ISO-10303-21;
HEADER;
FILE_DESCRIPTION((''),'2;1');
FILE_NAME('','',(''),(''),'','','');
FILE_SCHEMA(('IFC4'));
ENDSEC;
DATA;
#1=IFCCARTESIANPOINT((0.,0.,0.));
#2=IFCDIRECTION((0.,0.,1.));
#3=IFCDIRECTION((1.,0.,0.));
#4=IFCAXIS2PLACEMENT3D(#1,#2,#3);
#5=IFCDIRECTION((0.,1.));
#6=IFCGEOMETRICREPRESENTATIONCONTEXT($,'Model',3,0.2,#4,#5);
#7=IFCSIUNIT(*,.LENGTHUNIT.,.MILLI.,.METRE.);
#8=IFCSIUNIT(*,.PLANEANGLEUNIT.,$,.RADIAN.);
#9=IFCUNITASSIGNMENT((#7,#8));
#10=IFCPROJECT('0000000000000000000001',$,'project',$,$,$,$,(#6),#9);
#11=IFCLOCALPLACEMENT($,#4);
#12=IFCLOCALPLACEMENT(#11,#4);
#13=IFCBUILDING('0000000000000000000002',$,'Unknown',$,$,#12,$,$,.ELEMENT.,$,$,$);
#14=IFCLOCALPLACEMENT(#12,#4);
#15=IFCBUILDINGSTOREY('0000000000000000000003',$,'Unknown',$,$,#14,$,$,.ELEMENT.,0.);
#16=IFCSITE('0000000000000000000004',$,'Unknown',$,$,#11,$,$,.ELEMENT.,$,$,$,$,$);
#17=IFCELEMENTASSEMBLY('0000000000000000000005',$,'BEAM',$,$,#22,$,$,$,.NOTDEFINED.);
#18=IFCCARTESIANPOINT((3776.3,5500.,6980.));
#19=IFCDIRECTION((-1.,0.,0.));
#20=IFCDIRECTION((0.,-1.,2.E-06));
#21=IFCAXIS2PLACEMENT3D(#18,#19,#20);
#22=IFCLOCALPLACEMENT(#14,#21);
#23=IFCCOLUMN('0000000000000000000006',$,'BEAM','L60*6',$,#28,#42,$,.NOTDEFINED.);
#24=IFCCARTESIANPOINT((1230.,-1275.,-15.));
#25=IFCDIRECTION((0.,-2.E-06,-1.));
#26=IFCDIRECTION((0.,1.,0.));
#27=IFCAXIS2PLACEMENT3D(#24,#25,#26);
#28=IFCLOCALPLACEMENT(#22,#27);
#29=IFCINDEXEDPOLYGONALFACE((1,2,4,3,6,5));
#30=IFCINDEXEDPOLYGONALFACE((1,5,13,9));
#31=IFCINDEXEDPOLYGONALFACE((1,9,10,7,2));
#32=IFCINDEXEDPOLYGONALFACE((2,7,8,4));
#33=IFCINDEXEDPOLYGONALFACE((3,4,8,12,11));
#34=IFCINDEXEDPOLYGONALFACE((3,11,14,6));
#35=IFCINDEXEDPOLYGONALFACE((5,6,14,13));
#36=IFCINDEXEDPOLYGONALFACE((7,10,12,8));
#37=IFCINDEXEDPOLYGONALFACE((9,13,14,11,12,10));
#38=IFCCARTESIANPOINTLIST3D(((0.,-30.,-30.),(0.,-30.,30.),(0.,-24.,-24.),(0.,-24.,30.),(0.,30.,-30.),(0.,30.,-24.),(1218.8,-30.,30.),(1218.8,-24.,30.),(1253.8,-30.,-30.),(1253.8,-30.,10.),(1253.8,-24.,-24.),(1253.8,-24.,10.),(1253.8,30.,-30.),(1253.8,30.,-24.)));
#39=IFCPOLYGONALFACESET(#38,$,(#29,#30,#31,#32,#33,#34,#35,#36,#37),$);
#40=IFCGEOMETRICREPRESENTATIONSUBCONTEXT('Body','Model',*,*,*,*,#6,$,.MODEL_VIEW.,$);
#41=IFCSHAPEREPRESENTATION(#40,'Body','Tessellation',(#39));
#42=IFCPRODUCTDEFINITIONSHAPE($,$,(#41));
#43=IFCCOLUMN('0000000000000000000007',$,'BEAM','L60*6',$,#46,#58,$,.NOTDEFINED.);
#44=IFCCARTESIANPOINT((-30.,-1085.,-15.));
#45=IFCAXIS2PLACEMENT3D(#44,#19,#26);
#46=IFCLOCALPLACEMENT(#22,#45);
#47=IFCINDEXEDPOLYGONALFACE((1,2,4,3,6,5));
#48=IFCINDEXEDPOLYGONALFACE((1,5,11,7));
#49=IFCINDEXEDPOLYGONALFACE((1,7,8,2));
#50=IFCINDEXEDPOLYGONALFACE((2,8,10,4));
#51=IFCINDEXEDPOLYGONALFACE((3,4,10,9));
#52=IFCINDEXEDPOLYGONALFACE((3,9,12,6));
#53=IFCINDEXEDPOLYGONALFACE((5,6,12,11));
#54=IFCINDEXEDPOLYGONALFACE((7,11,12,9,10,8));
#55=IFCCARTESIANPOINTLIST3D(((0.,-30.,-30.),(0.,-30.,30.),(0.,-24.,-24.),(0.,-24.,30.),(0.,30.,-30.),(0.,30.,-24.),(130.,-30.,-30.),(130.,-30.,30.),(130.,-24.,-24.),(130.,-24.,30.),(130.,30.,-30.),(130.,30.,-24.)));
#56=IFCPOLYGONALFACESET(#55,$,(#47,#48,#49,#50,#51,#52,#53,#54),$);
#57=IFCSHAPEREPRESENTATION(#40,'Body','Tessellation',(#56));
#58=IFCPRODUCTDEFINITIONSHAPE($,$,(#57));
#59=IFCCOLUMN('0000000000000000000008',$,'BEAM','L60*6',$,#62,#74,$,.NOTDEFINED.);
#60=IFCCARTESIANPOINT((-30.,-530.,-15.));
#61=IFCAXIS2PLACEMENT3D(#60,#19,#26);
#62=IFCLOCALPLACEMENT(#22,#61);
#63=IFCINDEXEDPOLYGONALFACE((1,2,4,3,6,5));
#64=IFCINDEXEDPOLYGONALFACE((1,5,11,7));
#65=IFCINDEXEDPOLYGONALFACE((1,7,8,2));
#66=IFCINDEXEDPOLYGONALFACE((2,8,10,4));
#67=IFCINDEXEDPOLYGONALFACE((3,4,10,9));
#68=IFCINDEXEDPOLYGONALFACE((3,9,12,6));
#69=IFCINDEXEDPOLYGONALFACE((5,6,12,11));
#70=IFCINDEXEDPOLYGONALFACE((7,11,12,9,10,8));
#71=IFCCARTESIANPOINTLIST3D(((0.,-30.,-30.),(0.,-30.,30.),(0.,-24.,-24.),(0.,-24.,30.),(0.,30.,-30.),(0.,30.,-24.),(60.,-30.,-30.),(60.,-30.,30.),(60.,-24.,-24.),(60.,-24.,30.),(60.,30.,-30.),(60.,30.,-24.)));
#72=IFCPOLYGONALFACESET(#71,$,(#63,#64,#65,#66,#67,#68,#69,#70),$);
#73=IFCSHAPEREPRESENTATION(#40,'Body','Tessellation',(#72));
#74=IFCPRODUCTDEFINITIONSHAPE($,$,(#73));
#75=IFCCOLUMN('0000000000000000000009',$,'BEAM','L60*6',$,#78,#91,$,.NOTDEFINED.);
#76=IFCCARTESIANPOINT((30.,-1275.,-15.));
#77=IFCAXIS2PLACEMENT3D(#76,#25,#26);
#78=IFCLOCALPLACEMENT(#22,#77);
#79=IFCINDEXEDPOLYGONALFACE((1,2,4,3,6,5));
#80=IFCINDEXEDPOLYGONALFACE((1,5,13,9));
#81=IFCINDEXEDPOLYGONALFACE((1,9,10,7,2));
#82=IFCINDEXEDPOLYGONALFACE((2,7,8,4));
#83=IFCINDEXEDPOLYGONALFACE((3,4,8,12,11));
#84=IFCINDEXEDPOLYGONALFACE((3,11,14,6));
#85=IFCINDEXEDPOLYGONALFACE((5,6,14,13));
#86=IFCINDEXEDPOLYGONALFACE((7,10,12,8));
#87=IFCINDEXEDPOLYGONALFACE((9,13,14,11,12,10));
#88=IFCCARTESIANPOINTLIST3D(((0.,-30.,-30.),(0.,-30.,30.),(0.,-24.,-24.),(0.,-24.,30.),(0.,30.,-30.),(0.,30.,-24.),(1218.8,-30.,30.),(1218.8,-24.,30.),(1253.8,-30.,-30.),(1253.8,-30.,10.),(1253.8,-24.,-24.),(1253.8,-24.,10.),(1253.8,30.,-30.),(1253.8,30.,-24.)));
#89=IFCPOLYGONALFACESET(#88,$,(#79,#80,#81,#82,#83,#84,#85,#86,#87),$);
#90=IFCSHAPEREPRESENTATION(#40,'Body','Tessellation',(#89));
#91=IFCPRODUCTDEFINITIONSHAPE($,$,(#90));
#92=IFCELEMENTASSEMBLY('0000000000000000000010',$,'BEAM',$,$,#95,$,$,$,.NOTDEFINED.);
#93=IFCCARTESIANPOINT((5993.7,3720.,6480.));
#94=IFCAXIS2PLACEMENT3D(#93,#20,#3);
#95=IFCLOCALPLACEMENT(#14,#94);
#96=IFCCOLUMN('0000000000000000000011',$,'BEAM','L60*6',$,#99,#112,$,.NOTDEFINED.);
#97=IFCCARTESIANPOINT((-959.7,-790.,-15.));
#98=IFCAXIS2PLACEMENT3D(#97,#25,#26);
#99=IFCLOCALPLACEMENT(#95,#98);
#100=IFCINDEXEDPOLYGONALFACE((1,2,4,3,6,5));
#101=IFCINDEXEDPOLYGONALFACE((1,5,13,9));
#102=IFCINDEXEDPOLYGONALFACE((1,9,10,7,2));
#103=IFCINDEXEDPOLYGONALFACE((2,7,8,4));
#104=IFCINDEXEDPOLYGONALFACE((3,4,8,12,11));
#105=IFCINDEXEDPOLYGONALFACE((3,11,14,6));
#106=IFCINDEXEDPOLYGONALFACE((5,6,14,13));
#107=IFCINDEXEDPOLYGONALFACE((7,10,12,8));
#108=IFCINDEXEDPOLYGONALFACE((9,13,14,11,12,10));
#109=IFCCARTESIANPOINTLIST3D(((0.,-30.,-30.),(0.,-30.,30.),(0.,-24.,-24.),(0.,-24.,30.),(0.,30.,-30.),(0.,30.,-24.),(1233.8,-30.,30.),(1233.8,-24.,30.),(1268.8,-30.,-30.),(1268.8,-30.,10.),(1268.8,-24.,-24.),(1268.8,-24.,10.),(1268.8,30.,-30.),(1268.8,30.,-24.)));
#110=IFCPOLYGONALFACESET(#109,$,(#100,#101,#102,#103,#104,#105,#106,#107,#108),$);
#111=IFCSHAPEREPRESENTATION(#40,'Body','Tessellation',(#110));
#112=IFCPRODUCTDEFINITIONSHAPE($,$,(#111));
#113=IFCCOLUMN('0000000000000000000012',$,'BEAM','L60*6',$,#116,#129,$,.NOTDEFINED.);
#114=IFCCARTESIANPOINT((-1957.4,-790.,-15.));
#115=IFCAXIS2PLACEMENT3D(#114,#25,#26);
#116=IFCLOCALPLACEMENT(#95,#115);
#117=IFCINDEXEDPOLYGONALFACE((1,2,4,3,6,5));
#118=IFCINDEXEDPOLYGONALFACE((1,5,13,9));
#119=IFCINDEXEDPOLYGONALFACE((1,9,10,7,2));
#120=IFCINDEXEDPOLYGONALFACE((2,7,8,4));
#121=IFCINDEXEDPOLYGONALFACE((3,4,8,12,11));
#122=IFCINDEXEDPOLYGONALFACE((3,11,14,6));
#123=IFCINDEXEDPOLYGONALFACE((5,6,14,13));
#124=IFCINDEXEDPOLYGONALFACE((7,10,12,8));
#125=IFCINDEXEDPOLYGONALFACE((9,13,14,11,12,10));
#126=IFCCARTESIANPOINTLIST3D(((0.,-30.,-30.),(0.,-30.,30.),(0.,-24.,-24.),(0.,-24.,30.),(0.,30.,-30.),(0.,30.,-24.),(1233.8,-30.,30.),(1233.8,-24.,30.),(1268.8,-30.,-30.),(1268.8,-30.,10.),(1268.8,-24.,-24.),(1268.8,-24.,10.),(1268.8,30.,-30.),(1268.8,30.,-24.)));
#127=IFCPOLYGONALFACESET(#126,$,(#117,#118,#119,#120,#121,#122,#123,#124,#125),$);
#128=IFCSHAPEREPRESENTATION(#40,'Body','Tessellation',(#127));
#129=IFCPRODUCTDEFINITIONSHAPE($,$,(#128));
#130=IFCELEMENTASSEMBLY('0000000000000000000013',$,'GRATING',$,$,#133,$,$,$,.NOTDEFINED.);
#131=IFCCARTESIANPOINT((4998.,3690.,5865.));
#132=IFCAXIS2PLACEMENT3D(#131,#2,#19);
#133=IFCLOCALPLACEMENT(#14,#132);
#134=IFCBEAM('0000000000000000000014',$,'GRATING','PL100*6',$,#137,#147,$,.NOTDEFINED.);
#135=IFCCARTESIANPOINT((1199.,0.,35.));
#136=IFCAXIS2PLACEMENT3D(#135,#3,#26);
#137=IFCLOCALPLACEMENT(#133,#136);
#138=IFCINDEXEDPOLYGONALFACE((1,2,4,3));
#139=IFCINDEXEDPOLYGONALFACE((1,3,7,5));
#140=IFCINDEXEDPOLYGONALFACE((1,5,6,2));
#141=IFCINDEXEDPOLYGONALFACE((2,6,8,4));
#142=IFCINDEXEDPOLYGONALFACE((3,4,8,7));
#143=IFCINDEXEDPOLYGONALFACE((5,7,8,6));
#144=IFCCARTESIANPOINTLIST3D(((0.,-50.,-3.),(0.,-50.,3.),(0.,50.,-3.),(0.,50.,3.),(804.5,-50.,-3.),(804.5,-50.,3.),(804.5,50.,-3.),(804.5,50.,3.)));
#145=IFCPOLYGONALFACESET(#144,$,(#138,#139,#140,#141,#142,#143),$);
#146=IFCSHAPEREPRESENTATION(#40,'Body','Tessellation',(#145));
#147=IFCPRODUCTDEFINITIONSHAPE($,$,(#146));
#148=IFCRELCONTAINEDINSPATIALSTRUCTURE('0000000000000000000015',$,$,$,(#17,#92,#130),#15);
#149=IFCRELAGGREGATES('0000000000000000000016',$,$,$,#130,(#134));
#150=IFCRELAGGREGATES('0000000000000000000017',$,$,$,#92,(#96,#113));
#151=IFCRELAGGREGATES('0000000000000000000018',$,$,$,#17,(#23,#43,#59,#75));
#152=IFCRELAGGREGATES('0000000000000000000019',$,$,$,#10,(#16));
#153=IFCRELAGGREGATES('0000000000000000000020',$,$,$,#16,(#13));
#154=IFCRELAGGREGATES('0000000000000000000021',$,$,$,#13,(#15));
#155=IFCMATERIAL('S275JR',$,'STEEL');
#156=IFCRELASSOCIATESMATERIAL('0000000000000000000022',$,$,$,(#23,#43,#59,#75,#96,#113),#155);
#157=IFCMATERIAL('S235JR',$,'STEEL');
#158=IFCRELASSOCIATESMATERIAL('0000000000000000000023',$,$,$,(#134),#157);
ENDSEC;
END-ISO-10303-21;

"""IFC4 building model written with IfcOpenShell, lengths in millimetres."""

from ifc_helpers import new_model, si_unit, direction, frame, origin_with_axes, place, context, subcontext, project, spatial, line, indexed_curve, outline, extrude, material, element, aggregate, save


model = new_model("IFC4")

# Units and contexts
model_context = context("Model", 3, precision=0.2, world=origin_with_axes(), true_north=direction((0.0, 1.0)))
body_context = subcontext(model_context, "Body", "Model", "MODEL_VIEW")
ifc_project = project(units=[si_unit("LENGTHUNIT", "METRE", prefix="MILLI"), si_unit("PLANEANGLEUNIT", "RADIAN")], contexts=[model_context])

# Site, building, storey
site_placement = place(None, origin_with_axes())
site = spatial("IfcSite", under=ifc_project, at=site_placement, Name="Unknown", CompositionType="ELEMENT")
building_placement = place(site_placement, origin_with_axes())
building = spatial("IfcBuilding", under=site, at=building_placement, Name="Unknown", CompositionType="ELEMENT")
storey_placement = place(building_placement, origin_with_axes())
storey = spatial("IfcBuildingStorey", under=building, at=storey_placement, Name="Unknown", CompositionType="ELEMENT", Elevation=0.0)

# Element assemblies, columns, voiding features
assembly_1_placement = place(storey_placement, frame((3776.3, 5500.0, 6980.0), z_axis=(-1.0, 0.0, 0.0), x_axis=(0.0, -1.0, 0.000002)))
assembly_1 = element("IfcElementAssembly", 1, at=assembly_1_placement, inside=storey, Name="BEAM", PredefinedType="NOTDEFINED")
ifc_material_1 = material(Name="S275JR", Category="STEEL")
column_1_placement = place(assembly_1_placement, frame((1230.0, -1275.0, -15.0), z_axis=(0.0, -0.000002, -1.0), x_axis=(0.0, 1.0, 0.0)))
column_1 = element("IfcColumn", 2, at=column_1_placement, material=ifc_material_1, Name="BEAM", Description="L60*6", PredefinedType="NOTDEFINED", context=body_context, shape_type="SolidModel", body=[
    extrude(outline(indexed_curve([(-30.0, -30.0), (30.0, -30.0), (30.0, -24.0), (-24.0, -24.0), (-24.0, 30.0), (-30.0, 30.0)], segments=[line(1, 2, 3, 4, 5, 6, 1)])), frame((0.0, 0.0, 0.0), z_axis=(-1.0, 0.0, 0.0), x_axis=(0.0, 0.0, 1.0)), (0.0, -0.000002, -1.0), 1253.8),
])
voiding_feature_1_placement = place(column_1_placement, frame((1253.8, 0.0, 10.0), z_axis=(0.0, -1.0, 0.000002), x_axis=(0.0, 0.0, 1.0)))
element("IfcVoidingFeature", 3, at=voiding_feature_1_placement, cuts=column_1, Name="CUTPART", PredefinedType="HOLE", context=body_context, shape_type="SolidModel", body=[
    extrude(outline(indexed_curve([(0.0, 0.0), (20.0, 0.0), (20.0, 35.0)], segments=[line(1, 2, 3, 1)])), frame((0.0, 0.0, 33.0), z_axis=(0.0, 0.0, 1.0), x_axis=(1.0, 0.0, 0.0)), (0.0, -0.000002, -1.0), 66.0),
])
column_2_placement = place(assembly_1_placement, frame((-30.0, -1085.0, -15.0), z_axis=(-1.0, 0.0, 0.0), x_axis=(0.0, 1.0, 0.0)))
column_2 = element("IfcColumn", 4, at=column_2_placement, material=ifc_material_1, Name="BEAM", Description="L60*6", PredefinedType="NOTDEFINED", context=body_context, shape_type="SolidModel", body=[
    extrude(outline(indexed_curve([(-30.0, -30.0), (30.0, -30.0), (30.0, -24.0), (-24.0, -24.0), (-24.0, 30.0), (-30.0, 30.0)], segments=[line(1, 2, 3, 4, 5, 6, 1)])), frame((0.0, 0.0, 0.0), z_axis=(-1.0, 0.0, 0.0), x_axis=(0.0, 0.0, 1.0)), (0.0, -0.000002, -1.0), 130.0),
])
column_3_placement = place(assembly_1_placement, frame((-30.0, -530.0, -15.0), z_axis=(-1.0, 0.0, 0.0), x_axis=(0.0, 1.0, 0.0)))
column_3 = element("IfcColumn", 5, at=column_3_placement, material=ifc_material_1, Name="BEAM", Description="L60*6", PredefinedType="NOTDEFINED", context=body_context, shape_type="SolidModel", body=[
    extrude(outline(indexed_curve([(-30.0, -30.0), (30.0, -30.0), (30.0, -24.0), (-24.0, -24.0), (-24.0, 30.0), (-30.0, 30.0)], segments=[line(1, 2, 3, 4, 5, 6, 1)])), frame((0.0, 0.0, 0.0), z_axis=(-1.0, 0.0, 0.0), x_axis=(0.0, 0.0, 1.0)), (0.0, -0.000002, -1.0), 60.0),
])
column_4_placement = place(assembly_1_placement, frame((30.0, -1275.0, -15.0), z_axis=(0.0, -0.000002, -1.0), x_axis=(0.0, 1.0, 0.0)))
column_4 = element("IfcColumn", 6, at=column_4_placement, material=ifc_material_1, Name="BEAM", Description="L60*6", PredefinedType="NOTDEFINED", context=body_context, shape_type="SolidModel", body=[
    extrude(outline(indexed_curve([(-30.0, -30.0), (30.0, -30.0), (30.0, -24.0), (-24.0, -24.0), (-24.0, 30.0), (-30.0, 30.0)], segments=[line(1, 2, 3, 4, 5, 6, 1)])), frame((0.0, 0.0, 0.0), z_axis=(-1.0, 0.0, 0.0), x_axis=(0.0, 0.0, 1.0)), (0.0, -0.000002, -1.0), 1253.8),
])
voiding_feature_2_placement = place(column_4_placement, frame((1253.8, 0.0, 10.0), z_axis=(0.0, -1.0, 0.000002), x_axis=(0.0, 0.0, 1.0)))
element("IfcVoidingFeature", 7, at=voiding_feature_2_placement, cuts=column_4, Name="CUTPART", PredefinedType="HOLE", context=body_context, shape_type="SolidModel", body=[
    extrude(outline(indexed_curve([(0.0, 0.0), (20.0, 0.0), (20.0, 35.0)], segments=[line(1, 2, 3, 1)])), frame((0.0, 0.0, 33.0), z_axis=(0.0, 0.0, 1.0), x_axis=(1.0, 0.0, 0.0)), (0.0, -0.000002, -1.0), 66.0),
])
assembly_2_placement = place(storey_placement, frame((5993.7, 3720.0, 6480.0), z_axis=(0.0, -1.0, 0.000002), x_axis=(1.0, 0.0, 0.0)))
assembly_2 = element("IfcElementAssembly", 8, at=assembly_2_placement, inside=storey, Name="BEAM", PredefinedType="NOTDEFINED")
column_5_placement = place(assembly_2_placement, frame((-959.7, -790.0, -15.0), z_axis=(0.0, -0.000002, -1.0), x_axis=(0.0, 1.0, 0.0)))
column_5 = element("IfcColumn", 9, at=column_5_placement, material=ifc_material_1, Name="BEAM", Description="L60*6", PredefinedType="NOTDEFINED", context=body_context, shape_type="SolidModel", body=[
    extrude(outline(indexed_curve([(-30.0, -30.0), (30.0, -30.0), (30.0, -24.0), (-24.0, -24.0), (-24.0, 30.0), (-30.0, 30.0)], segments=[line(1, 2, 3, 4, 5, 6, 1)])), frame((0.0, 0.0, 0.0), z_axis=(-1.0, 0.0, 0.0), x_axis=(0.0, 0.0, 1.0)), (0.0, -0.000002, -1.0), 1268.8),
])
voiding_feature_3_placement = place(column_5_placement, frame((1268.8, 0.0, 10.0), z_axis=(0.0, -1.0, 0.000002), x_axis=(0.0, 0.0, 1.0)))
element("IfcVoidingFeature", 10, at=voiding_feature_3_placement, cuts=column_5, Name="CUTPART", PredefinedType="HOLE", context=body_context, shape_type="SolidModel", body=[
    extrude(outline(indexed_curve([(0.0, 0.0), (20.0, 0.0), (20.0, 35.0)], segments=[line(1, 2, 3, 1)])), frame((0.0, 0.0, 33.0), z_axis=(0.0, 0.0, 1.0), x_axis=(1.0, 0.0, 0.0)), (0.0, -0.000002, -1.0), 66.0),
])
column_6_placement = place(assembly_2_placement, frame((-1957.4, -790.0, -15.0), z_axis=(0.0, -0.000002, -1.0), x_axis=(0.0, 1.0, 0.0)))
column_6 = element("IfcColumn", 11, at=column_6_placement, material=ifc_material_1, Name="BEAM", Description="L60*6", PredefinedType="NOTDEFINED", context=body_context, shape_type="SolidModel", body=[
    extrude(outline(indexed_curve([(-30.0, -30.0), (30.0, -30.0), (30.0, -24.0), (-24.0, -24.0), (-24.0, 30.0), (-30.0, 30.0)], segments=[line(1, 2, 3, 4, 5, 6, 1)])), frame((0.0, 0.0, 0.0), z_axis=(-1.0, 0.0, 0.0), x_axis=(0.0, 0.0, 1.0)), (0.0, -0.000002, -1.0), 1268.8),
])
voiding_feature_4_placement = place(column_6_placement, frame((1268.8, 0.0, 10.0), z_axis=(0.0, -1.0, 0.000002), x_axis=(0.0, 0.0, 1.0)))
element("IfcVoidingFeature", 12, at=voiding_feature_4_placement, cuts=column_6, Name="CUTPART", PredefinedType="HOLE", context=body_context, shape_type="SolidModel", body=[
    extrude(outline(indexed_curve([(0.0, 0.0), (20.0, 0.0), (20.0, 35.0)], segments=[line(1, 2, 3, 1)])), frame((0.0, 0.0, 33.0), z_axis=(0.0, 0.0, 1.0), x_axis=(1.0, 0.0, 0.0)), (0.0, -0.000002, -1.0), 66.0),
])

# Element assembly, beam
assembly_3_placement = place(storey_placement, frame((4998.0, 3690.0, 5865.0), z_axis=(0.0, 0.0, 1.0), x_axis=(-1.0, 0.0, 0.0)))
assembly_3 = element("IfcElementAssembly", 13, at=assembly_3_placement, inside=storey, Name="GRATING", PredefinedType="NOTDEFINED")
ifc_material_2 = material(Name="S235JR", Category="STEEL")
beam_placement = place(assembly_3_placement, frame((1199.0, 0.0, 35.0), z_axis=(1.0, 0.0, 0.0), x_axis=(0.0, 1.0, 0.0)))
beam = element("IfcBeam", 14, at=beam_placement, material=ifc_material_2, Name="GRATING", Description="PL100*6", PredefinedType="NOTDEFINED", context=body_context, shape_type="SolidModel", body=[
    extrude(outline(indexed_curve([(-3.0, -50.0), (3.0, -50.0), (3.0, 50.0), (-3.0, 50.0)], segments=[line(1, 2, 3, 4, 1)])), frame((0.0, 0.0, 0.0), z_axis=(-1.0, 0.0, 0.0), x_axis=(0.0, 0.0, 1.0)), (0.0, -0.000002, -1.0), 804.5),
])
aggregate(assembly_3, [beam])

aggregate(assembly_2, [column_5, column_6])
aggregate(assembly_1, [column_1, column_2, column_3, column_4])

save(model, "model.ifc")
